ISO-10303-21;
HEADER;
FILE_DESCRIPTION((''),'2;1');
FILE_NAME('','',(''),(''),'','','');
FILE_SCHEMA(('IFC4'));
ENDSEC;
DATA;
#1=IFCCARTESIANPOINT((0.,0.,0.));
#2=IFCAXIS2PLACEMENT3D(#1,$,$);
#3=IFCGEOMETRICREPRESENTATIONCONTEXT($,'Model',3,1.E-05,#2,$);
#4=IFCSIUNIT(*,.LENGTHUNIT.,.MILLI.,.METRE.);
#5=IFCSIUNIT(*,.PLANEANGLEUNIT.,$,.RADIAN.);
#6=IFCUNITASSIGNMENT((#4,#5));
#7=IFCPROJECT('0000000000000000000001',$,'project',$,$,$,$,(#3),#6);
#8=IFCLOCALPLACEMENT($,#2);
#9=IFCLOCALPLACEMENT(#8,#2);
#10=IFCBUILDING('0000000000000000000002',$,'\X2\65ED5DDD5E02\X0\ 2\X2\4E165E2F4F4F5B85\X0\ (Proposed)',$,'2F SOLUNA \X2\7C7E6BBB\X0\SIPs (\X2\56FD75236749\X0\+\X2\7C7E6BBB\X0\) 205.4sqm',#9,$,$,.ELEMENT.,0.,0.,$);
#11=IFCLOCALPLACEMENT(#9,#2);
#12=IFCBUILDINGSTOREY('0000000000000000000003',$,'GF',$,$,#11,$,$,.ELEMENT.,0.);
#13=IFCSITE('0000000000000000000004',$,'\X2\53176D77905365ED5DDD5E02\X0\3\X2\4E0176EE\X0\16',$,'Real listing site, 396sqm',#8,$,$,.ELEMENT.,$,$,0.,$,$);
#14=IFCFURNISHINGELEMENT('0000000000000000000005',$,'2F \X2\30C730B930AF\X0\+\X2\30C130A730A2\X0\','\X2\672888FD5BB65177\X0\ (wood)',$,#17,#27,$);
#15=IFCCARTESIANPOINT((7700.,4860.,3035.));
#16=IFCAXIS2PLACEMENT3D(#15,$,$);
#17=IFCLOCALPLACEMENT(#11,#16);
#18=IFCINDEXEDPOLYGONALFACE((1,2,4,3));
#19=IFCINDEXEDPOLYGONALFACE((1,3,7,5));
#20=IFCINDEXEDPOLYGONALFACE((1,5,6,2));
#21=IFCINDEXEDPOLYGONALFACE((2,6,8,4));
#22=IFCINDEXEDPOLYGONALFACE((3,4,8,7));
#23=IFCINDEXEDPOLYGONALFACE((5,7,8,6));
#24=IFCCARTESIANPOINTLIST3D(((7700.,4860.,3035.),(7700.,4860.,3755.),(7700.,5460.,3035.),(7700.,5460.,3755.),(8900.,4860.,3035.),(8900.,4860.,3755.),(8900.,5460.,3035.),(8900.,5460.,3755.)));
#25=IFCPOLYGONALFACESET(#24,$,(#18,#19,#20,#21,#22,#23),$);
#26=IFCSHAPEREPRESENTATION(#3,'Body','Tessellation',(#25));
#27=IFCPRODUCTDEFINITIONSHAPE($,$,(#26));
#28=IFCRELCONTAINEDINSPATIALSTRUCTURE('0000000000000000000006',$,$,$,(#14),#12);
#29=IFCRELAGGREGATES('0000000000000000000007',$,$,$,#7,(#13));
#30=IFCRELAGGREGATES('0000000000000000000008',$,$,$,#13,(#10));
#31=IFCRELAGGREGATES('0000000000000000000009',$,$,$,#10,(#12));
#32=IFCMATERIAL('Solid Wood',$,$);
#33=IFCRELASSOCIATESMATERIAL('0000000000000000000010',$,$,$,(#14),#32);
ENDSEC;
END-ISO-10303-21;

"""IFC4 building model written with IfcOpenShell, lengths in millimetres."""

from ifc_helpers import new_model, si_unit, frame, frame_2d, origin, place, context, project, spatial, rectangle, extrude, material, element, save


model = new_model("IFC4")

# Units and contexts
model_context = context("Model", 3, precision=1e-05, world=origin())
ifc_project = project(units=[si_unit("LENGTHUNIT", "METRE", prefix="MILLI"), si_unit("PLANEANGLEUNIT", "RADIAN")], contexts=[model_context])

# Site, building, storey
site_placement = place(None, origin())
site = spatial("IfcSite", under=ifc_project, at=site_placement, Name="北海道旭川市3丁目16", ObjectType="Real listing site, 396sqm", CompositionType="ELEMENT", RefElevation=0.0)
building_placement = place(site_placement, origin())
building = spatial("IfcBuilding", under=site, at=building_placement, Name="旭川市 2世帯住宅 (Proposed)", ObjectType="2F SOLUNA 籾殻SIPs (国産杉+籾殻) 205.4sqm", CompositionType="ELEMENT", ElevationOfRefHeight=0.0, ElevationOfTerrain=0.0)
storey_placement = place(building_placement, origin())
storey = spatial("IfcBuildingStorey", under=building, at=storey_placement, Name="GF", CompositionType="ELEMENT", Elevation=0.0)

# Shared definitions
ifc_material_1 = material(Name="Solid Wood")

# Furnishing element
furnishing_1_placement = place(storey_placement, frame((7700.0, 4860.0, 3035.0)))
element("IfcFurnishingElement", 1, at=furnishing_1_placement, inside=storey, material=ifc_material_1, Name="2F デスク+チェア", Description="木製家具 (wood)", context=model_context, shape_type="SweptSolid", body=[
    extrude(rectangle(XDim=1200.0, YDim=600.0, at=frame_2d((600.0, 300.0))), frame((7700.0, 4860.0, 3035.0)), (0.0, 0.0, 1.0), 720.0),
])

save(model, "model.ifc")
